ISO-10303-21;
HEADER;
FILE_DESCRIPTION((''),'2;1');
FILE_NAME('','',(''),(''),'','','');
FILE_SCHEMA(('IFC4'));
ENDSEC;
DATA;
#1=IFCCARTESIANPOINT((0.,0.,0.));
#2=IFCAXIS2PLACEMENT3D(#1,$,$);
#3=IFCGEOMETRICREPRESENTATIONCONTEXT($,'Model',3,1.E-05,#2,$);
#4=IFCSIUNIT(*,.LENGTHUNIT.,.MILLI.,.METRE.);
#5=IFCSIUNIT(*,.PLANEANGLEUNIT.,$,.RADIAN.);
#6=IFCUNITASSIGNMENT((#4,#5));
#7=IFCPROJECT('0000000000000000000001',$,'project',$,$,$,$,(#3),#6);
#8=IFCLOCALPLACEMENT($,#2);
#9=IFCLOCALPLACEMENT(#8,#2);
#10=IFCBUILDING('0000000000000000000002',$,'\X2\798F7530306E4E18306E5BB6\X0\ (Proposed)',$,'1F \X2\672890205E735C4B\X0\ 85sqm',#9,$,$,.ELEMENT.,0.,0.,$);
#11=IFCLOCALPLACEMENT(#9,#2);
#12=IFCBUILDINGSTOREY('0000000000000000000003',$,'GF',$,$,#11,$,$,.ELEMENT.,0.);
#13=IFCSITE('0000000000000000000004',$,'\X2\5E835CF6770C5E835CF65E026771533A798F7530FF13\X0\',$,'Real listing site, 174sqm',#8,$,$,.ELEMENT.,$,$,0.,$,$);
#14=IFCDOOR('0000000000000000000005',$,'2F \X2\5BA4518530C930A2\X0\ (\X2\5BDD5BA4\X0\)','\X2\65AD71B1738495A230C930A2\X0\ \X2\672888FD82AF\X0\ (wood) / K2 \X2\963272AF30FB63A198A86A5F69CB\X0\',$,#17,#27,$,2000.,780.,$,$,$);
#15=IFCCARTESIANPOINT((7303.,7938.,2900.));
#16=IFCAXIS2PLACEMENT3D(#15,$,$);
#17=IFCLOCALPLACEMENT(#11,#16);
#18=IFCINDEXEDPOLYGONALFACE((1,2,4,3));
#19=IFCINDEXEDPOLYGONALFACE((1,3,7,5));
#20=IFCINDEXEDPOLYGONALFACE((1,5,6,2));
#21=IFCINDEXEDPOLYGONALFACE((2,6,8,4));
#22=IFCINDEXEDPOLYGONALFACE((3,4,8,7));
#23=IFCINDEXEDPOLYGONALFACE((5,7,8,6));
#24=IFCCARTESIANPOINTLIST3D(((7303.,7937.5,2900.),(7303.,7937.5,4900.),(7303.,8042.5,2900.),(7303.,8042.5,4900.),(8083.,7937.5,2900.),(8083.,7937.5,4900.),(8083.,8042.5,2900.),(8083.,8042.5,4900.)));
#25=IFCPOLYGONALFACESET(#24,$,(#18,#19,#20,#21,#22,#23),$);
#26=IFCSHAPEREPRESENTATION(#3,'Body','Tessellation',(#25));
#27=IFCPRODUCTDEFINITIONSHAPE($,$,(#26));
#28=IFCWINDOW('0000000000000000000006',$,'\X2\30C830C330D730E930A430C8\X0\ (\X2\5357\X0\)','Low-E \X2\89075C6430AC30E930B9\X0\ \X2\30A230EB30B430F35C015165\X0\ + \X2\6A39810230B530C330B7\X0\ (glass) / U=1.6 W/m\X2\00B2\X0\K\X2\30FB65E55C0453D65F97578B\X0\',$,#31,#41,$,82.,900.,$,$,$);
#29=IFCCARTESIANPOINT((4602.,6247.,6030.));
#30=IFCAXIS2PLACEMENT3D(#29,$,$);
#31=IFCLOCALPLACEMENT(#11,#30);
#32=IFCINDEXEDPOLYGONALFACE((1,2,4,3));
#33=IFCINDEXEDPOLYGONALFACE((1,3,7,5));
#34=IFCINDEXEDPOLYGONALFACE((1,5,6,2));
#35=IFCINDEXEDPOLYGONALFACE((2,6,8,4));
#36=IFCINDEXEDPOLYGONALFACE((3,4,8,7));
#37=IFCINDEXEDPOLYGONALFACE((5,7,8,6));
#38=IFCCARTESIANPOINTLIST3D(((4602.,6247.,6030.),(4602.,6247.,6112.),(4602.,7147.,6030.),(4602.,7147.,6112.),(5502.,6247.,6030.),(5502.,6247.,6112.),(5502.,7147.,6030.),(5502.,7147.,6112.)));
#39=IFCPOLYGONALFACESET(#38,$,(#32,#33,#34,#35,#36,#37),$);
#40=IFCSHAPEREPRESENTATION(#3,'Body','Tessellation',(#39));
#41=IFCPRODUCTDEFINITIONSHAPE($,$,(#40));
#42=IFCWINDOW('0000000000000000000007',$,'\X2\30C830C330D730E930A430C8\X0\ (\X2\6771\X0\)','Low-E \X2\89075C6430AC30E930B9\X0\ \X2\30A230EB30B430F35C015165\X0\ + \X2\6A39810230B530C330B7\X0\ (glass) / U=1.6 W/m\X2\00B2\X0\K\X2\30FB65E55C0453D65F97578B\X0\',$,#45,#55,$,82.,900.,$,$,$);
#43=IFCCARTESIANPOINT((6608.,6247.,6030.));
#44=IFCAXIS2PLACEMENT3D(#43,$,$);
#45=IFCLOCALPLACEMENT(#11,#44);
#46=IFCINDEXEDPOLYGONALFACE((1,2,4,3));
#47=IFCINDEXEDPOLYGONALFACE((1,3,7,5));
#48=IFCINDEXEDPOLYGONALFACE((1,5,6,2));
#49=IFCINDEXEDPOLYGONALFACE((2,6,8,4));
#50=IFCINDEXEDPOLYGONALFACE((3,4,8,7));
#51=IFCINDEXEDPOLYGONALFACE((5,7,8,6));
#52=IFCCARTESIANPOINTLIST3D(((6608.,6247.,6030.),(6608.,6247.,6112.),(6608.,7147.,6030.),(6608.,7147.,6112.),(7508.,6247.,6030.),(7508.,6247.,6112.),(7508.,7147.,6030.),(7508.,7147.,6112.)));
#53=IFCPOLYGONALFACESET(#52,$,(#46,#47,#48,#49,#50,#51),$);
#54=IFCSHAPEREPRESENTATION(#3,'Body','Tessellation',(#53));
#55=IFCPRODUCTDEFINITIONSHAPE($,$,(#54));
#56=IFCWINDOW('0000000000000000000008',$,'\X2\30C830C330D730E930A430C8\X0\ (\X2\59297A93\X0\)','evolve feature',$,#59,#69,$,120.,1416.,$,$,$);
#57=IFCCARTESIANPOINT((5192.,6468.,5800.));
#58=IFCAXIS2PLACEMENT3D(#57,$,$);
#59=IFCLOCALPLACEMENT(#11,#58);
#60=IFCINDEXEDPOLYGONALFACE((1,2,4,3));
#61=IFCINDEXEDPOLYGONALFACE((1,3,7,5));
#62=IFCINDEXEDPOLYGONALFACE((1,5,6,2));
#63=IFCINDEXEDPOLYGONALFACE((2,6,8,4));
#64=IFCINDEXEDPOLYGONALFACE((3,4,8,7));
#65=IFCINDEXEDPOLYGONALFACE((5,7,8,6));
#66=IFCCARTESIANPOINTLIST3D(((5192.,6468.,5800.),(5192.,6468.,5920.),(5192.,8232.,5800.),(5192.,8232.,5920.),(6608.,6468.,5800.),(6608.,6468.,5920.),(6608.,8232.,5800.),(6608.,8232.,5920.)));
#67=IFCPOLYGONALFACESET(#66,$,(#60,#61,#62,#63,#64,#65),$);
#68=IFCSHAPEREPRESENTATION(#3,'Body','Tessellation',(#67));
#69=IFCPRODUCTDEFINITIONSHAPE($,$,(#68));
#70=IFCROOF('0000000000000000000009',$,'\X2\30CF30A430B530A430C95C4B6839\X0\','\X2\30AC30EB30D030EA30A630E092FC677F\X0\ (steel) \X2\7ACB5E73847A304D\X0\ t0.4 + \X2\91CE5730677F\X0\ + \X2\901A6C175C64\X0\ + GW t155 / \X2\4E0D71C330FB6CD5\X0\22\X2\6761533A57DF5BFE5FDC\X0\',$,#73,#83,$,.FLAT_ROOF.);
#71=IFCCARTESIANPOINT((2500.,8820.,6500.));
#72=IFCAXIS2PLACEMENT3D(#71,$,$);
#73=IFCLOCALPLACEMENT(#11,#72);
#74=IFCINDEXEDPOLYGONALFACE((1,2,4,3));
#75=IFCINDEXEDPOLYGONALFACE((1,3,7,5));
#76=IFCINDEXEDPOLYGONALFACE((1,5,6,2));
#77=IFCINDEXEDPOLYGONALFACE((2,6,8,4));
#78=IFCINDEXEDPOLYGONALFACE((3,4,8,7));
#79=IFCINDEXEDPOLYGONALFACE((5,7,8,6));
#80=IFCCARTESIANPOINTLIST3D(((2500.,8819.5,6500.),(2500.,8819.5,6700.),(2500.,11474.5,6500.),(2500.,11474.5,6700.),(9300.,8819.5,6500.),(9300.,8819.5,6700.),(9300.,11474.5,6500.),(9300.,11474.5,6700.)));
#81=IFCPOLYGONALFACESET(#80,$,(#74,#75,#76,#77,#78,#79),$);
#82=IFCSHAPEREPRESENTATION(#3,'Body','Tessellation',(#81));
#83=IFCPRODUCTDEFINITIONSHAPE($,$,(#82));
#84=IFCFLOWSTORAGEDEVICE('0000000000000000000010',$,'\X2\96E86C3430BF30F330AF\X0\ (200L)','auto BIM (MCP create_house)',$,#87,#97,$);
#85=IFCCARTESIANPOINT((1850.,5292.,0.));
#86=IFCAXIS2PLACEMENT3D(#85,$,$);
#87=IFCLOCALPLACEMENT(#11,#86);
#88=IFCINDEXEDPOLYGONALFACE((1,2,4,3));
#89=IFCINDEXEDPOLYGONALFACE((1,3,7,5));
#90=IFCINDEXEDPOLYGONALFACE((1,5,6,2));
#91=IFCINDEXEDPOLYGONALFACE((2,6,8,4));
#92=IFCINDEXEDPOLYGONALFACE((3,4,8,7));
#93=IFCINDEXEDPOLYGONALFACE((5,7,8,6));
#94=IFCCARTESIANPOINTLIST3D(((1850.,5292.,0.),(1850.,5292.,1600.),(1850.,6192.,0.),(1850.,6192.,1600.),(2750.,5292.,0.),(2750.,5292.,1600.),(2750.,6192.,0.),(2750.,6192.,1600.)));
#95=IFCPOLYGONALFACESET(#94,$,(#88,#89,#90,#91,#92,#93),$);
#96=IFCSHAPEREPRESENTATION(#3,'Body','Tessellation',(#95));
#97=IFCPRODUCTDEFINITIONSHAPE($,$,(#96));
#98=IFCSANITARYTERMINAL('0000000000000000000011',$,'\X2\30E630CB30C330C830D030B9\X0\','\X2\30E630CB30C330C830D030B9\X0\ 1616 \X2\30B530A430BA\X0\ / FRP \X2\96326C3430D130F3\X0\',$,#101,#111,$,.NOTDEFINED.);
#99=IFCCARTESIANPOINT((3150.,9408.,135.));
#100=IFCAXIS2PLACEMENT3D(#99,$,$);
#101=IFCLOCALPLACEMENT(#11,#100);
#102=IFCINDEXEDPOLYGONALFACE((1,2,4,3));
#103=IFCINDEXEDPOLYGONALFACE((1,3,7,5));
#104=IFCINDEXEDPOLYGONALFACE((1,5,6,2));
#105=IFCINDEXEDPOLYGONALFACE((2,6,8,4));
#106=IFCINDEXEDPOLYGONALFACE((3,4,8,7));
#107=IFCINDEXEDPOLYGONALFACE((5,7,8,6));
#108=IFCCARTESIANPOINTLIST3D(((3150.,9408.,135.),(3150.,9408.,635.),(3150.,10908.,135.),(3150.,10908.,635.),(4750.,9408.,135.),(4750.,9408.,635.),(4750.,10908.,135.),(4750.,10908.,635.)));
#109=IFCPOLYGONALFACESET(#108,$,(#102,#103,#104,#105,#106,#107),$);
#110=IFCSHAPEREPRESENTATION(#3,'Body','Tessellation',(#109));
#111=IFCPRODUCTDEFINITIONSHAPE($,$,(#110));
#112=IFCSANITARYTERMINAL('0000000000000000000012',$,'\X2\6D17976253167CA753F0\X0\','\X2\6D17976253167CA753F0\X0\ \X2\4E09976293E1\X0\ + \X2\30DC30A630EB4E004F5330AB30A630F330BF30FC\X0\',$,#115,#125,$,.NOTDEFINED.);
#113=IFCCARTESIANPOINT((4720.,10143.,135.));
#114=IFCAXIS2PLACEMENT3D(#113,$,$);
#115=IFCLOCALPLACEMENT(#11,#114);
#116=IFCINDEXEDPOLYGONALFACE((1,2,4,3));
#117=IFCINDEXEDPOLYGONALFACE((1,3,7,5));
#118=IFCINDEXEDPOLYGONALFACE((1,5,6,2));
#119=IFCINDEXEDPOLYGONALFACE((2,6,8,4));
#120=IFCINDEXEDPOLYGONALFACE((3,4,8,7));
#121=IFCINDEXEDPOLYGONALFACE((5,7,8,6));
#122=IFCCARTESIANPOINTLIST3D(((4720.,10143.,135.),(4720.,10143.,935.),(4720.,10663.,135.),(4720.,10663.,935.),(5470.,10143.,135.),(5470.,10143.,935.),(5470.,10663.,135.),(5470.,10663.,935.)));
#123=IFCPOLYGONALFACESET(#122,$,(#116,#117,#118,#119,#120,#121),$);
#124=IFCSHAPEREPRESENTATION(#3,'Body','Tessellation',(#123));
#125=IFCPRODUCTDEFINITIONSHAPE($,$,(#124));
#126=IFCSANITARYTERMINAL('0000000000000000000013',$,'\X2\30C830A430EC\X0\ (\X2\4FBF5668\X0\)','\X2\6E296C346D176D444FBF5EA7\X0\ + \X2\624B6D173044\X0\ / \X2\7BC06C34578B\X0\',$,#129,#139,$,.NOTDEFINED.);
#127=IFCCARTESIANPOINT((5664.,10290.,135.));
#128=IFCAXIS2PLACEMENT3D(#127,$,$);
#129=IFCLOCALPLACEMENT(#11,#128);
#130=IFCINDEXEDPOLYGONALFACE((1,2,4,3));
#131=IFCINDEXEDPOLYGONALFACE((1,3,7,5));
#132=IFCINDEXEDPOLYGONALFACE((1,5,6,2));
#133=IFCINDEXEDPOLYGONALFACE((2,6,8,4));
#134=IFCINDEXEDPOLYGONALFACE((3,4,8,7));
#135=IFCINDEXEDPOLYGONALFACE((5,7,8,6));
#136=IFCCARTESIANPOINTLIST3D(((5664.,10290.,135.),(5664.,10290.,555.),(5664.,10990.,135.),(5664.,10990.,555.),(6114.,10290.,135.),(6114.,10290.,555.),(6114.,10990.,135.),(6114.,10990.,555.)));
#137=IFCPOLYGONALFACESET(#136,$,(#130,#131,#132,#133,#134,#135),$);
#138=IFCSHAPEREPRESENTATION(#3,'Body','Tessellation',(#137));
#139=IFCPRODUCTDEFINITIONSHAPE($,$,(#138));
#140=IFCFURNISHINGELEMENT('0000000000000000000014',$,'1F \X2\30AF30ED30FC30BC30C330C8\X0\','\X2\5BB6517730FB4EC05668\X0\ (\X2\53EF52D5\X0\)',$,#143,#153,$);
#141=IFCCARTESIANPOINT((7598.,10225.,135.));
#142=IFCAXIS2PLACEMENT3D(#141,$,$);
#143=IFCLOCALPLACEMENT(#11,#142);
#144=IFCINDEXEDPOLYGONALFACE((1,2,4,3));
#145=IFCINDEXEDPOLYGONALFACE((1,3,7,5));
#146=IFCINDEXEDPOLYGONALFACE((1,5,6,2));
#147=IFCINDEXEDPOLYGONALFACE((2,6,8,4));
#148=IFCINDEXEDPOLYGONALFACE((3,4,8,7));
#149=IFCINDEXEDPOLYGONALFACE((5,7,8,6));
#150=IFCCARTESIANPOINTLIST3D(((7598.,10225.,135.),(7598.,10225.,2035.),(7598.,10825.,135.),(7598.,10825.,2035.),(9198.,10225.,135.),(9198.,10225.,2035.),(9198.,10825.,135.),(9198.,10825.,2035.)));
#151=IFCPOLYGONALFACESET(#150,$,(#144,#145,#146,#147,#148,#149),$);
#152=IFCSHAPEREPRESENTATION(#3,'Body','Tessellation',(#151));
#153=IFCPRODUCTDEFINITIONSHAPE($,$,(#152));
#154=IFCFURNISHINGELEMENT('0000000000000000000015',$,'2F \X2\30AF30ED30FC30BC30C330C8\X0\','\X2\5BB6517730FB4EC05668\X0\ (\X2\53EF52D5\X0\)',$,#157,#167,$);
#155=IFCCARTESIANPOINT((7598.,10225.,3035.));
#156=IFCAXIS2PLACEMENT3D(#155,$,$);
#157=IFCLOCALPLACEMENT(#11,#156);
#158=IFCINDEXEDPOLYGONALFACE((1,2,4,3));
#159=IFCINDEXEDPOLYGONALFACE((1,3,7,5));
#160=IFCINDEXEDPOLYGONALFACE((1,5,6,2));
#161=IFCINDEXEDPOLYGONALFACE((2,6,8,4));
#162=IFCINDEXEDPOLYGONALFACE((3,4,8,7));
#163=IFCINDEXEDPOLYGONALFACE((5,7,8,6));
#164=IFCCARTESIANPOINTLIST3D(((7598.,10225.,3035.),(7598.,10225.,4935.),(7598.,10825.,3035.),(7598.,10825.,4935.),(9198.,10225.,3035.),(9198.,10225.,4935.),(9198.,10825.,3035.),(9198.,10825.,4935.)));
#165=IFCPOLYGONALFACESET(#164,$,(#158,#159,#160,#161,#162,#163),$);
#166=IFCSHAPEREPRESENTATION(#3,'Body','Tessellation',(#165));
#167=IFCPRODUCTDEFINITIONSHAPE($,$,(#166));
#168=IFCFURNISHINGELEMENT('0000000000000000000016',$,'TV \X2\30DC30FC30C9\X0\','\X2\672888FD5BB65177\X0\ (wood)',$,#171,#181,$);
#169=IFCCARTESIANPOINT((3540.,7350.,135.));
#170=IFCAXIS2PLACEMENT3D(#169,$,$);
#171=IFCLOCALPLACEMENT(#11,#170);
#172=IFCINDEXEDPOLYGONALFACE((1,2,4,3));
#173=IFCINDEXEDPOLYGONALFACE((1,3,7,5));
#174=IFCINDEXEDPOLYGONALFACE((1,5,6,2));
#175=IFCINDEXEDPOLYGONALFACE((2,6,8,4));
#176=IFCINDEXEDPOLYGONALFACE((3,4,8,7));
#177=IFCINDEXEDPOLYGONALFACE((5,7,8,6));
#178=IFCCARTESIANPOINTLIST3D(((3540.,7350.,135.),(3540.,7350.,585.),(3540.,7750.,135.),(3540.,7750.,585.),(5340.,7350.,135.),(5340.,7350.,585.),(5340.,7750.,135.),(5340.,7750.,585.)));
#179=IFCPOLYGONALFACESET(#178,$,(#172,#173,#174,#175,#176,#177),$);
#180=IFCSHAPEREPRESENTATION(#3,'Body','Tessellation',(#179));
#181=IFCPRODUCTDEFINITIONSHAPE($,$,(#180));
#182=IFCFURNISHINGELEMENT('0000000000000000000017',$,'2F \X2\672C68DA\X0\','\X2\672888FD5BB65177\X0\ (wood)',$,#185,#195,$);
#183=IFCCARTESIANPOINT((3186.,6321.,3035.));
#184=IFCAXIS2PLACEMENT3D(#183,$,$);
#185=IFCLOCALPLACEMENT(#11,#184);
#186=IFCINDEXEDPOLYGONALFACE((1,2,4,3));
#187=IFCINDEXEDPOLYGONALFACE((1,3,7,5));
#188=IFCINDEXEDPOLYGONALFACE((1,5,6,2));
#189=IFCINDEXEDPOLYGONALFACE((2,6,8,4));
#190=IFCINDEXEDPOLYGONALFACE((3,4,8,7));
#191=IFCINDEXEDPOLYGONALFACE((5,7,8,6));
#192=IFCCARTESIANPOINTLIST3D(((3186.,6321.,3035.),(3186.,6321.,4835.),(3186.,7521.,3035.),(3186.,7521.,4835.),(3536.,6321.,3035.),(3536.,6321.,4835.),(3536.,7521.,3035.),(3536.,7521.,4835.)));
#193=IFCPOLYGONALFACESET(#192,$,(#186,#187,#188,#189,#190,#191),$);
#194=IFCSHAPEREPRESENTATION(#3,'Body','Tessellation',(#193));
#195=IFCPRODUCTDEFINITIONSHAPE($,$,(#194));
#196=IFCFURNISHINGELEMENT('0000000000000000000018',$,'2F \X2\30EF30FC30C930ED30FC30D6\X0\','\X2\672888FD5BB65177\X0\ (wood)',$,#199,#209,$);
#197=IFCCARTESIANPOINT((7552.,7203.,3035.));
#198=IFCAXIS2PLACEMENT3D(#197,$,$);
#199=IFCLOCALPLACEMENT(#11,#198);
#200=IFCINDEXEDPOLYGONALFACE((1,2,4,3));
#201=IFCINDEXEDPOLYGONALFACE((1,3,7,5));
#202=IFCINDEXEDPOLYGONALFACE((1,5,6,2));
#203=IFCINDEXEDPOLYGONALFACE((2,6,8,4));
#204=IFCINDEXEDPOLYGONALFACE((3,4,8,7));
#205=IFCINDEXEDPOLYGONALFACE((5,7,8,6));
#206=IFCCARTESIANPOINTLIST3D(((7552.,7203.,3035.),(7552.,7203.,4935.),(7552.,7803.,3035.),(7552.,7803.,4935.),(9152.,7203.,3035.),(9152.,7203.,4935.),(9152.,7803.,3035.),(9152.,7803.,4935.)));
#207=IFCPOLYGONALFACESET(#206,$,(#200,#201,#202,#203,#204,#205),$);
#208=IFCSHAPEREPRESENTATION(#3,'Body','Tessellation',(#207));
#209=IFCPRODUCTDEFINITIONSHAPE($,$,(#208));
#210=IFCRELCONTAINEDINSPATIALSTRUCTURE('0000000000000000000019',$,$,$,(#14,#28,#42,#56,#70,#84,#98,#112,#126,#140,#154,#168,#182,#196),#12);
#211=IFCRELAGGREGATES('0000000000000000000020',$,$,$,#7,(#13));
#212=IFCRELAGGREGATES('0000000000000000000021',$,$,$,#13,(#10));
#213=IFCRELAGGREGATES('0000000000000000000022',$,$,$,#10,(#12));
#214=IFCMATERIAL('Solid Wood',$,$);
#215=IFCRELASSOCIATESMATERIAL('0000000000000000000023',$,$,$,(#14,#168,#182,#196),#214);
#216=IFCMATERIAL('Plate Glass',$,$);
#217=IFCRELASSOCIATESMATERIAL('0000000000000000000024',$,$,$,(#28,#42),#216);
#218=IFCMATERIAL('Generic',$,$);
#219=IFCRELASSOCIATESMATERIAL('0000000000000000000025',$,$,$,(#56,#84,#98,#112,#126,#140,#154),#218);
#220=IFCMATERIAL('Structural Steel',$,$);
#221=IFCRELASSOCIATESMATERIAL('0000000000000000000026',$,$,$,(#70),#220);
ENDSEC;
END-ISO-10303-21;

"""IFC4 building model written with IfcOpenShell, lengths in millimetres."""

from ifc_helpers import new_model, si_unit, frame, frame_2d, origin, place, context, project, spatial, rectangle, extrude, material, element, save


model = new_model("IFC4")

# Units and contexts
model_context = context("Model", 3, precision=1e-05, world=origin())
ifc_project = project(units=[si_unit("LENGTHUNIT", "METRE", prefix="MILLI"), si_unit("PLANEANGLEUNIT", "RADIAN")], contexts=[model_context])

# Site, building, storey
site_placement = place(None, origin())
site = spatial("IfcSite", under=ifc_project, at=site_placement, Name="広島県広島市東区福田３", ObjectType="Real listing site, 174sqm", CompositionType="ELEMENT", RefElevation=0.0)
building_placement = place(site_placement, origin())
building = spatial("IfcBuilding", under=site, at=building_placement, Name="福田の丘の家 (Proposed)", ObjectType="1F 木造平屋 85sqm", CompositionType="ELEMENT", ElevationOfRefHeight=0.0, ElevationOfTerrain=0.0)
storey_placement = place(building_placement, origin())
storey = spatial("IfcBuildingStorey", under=building, at=storey_placement, Name="GF", CompositionType="ELEMENT", Elevation=0.0)

# Shared definitions
ifc_material_1 = material(Name="Solid Wood")
ifc_material_2 = material(Name="Plate Glass")

# Door
door_1_placement = place(storey_placement, frame((7303.0, 7938.0, 2900.0)))
element("IfcDoor", 1, at=door_1_placement, inside=storey, material=ifc_material_1, Name="2F 室内ドア (寝室)", Description="断熱玄関ドア 木製芯 (wood) / K2 防犯・採風機構", OverallHeight=2000.0, OverallWidth=780.0, context=model_context, shape_type="SweptSolid", body=[
    extrude(rectangle(XDim=780.0, YDim=105.0, at=frame_2d((390.0, 52.0))), frame((7303.0, 7938.0, 2900.0)), (0.0, 0.0, 1.0), 2000.0),
])

# Windows
window_1_placement = place(storey_placement, frame((4602.0, 6247.0, 6030.0)))
element("IfcWindow", 2, at=window_1_placement, inside=storey, material=ifc_material_2, Name="トップライト (南)", Description="Low-E 複層ガラス アルゴン封入 + 樹脂サッシ (glass) / U=1.6 W/m²K・日射取得型", OverallHeight=82.0, OverallWidth=900.0, context=model_context, shape_type="SweptSolid", body=[
    extrude(rectangle(XDim=900.0, YDim=900.0, at=frame_2d((450.0, 450.0))), frame((4602.0, 6247.0, 6030.0)), (0.0, 0.0, 1.0), 82.0),
])
window_2_placement = place(storey_placement, frame((6608.0, 6247.0, 6030.0)))
element("IfcWindow", 3, at=window_2_placement, inside=storey, material=ifc_material_2, Name="トップライト (東)", Description="Low-E 複層ガラス アルゴン封入 + 樹脂サッシ (glass) / U=1.6 W/m²K・日射取得型", OverallHeight=82.0, OverallWidth=900.0, context=model_context, shape_type="SweptSolid", body=[
    extrude(rectangle(XDim=900.0, YDim=900.0, at=frame_2d((450.0, 450.0))), frame((6608.0, 6247.0, 6030.0)), (0.0, 0.0, 1.0), 82.0),
])
ifc_material_3 = material(Name="Generic")
window_3_placement = place(storey_placement, frame((5192.0, 6468.0, 5800.0)))
element("IfcWindow", 4, at=window_3_placement, inside=storey, material=ifc_material_3, Name="トップライト (天窓)", Description="evolve feature", OverallHeight=120.0, OverallWidth=1416.0, context=model_context, shape_type="SweptSolid", body=[
    extrude(rectangle(XDim=1416.0, YDim=1764.0, at=frame_2d((708.0, 882.0))), frame((5192.0, 6468.0, 5800.0)), (0.0, 0.0, 1.0), 120.0),
])

# Roof
ifc_material_4 = material(Name="Structural Steel")
roof_placement = place(storey_placement, frame((2500.0, 8820.0, 6500.0)))
element("IfcRoof", 5, at=roof_placement, inside=storey, material=ifc_material_4, Name="ハイサイド屋根", Description="ガルバリウム鋼板 (steel) 立平葺き t0.4 + 野地板 + 通気層 + GW t155 / 不燃・法22条区域対応", PredefinedType="FLAT_ROOF", context=model_context, shape_type="SweptSolid", body=[
    extrude(rectangle(XDim=6800.0, YDim=2655.0, at=frame_2d((3400.0, 1327.0))), frame((2500.0, 8820.0, 6500.0)), (0.0, 0.0, 1.0), 200.0),
])

# Flow storage device
flow_storage_device_placement = place(storey_placement, frame((1850.0, 5292.0, 0.0)))
element("IfcFlowStorageDevice", 6, at=flow_storage_device_placement, inside=storey, material=ifc_material_3, Name="雨水タンク (200L)", Description="auto BIM (MCP create_house)", context=model_context, shape_type="SweptSolid", body=[
    extrude(rectangle(XDim=900.0, YDim=900.0, at=frame_2d((450.0, 450.0))), frame((1850.0, 5292.0, 0.0)), (0.0, 0.0, 1.0), 1600.0),
])

# Sanitary terminals
sanitary_terminal_1_placement = place(storey_placement, frame((3150.0, 9408.0, 135.0)))
element("IfcSanitaryTerminal", 7, at=sanitary_terminal_1_placement, inside=storey, material=ifc_material_3, Name="ユニットバス", Description="ユニットバス 1616 サイズ / FRP 防水パン", PredefinedType="NOTDEFINED", context=model_context, shape_type="SweptSolid", body=[
    extrude(rectangle(XDim=1600.0, YDim=1500.0, at=frame_2d((800.0, 750.0))), frame((3150.0, 9408.0, 135.0)), (0.0, 0.0, 1.0), 500.0),
])
sanitary_terminal_2_placement = place(storey_placement, frame((4720.0, 10143.0, 135.0)))
element("IfcSanitaryTerminal", 8, at=sanitary_terminal_2_placement, inside=storey, material=ifc_material_3, Name="洗面化粧台", Description="洗面化粧台 三面鏡 + ボウル一体カウンター", PredefinedType="NOTDEFINED", context=model_context, shape_type="SweptSolid", body=[
    extrude(rectangle(XDim=750.0, YDim=520.0, at=frame_2d((375.0, 260.0))), frame((4720.0, 10143.0, 135.0)), (0.0, 0.0, 1.0), 800.0),
])
sanitary_terminal_3_placement = place(storey_placement, frame((5664.0, 10290.0, 135.0)))
element("IfcSanitaryTerminal", 9, at=sanitary_terminal_3_placement, inside=storey, material=ifc_material_3, Name="トイレ (便器)", Description="温水洗浄便座 + 手洗い / 節水型", PredefinedType="NOTDEFINED", context=model_context, shape_type="SweptSolid", body=[
    extrude(rectangle(XDim=450.0, YDim=700.0, at=frame_2d((225.0, 350.0))), frame((5664.0, 10290.0, 135.0)), (0.0, 0.0, 1.0), 420.0),
])

# Furnishing elements
furnishing_1_placement = place(storey_placement, frame((7598.0, 10225.0, 135.0)))
element("IfcFurnishingElement", 10, at=furnishing_1_placement, inside=storey, material=ifc_material_3, Name="1F クローゼット", Description="家具・什器 (可動)", context=model_context, shape_type="SweptSolid", body=[
    extrude(rectangle(XDim=1600.0, YDim=600.0, at=frame_2d((800.0, 300.0))), frame((7598.0, 10225.0, 135.0)), (0.0, 0.0, 1.0), 1900.0),
])
furnishing_2_placement = place(storey_placement, frame((7598.0, 10225.0, 3035.0)))
element("IfcFurnishingElement", 11, at=furnishing_2_placement, inside=storey, material=ifc_material_3, Name="2F クローゼット", Description="家具・什器 (可動)", context=model_context, shape_type="SweptSolid", body=[
    extrude(rectangle(XDim=1600.0, YDim=600.0, at=frame_2d((800.0, 300.0))), frame((7598.0, 10225.0, 3035.0)), (0.0, 0.0, 1.0), 1900.0),
])
furnishing_3_placement = place(storey_placement, frame((3540.0, 7350.0, 135.0)))
element("IfcFurnishingElement", 12, at=furnishing_3_placement, inside=storey, material=ifc_material_1, Name="TV ボード", Description="木製家具 (wood)", context=model_context, shape_type="SweptSolid", body=[
    extrude(rectangle(XDim=1800.0, YDim=400.0, at=frame_2d((900.0, 200.0))), frame((3540.0, 7350.0, 135.0)), (0.0, 0.0, 1.0), 450.0),
])
furnishing_4_placement = place(storey_placement, frame((3186.0, 6321.0, 3035.0)))
element("IfcFurnishingElement", 13, at=furnishing_4_placement, inside=storey, material=ifc_material_1, Name="2F 本棚", Description="木製家具 (wood)", context=model_context, shape_type="SweptSolid", body=[
    extrude(rectangle(XDim=350.0, YDim=1200.0, at=frame_2d((175.0, 600.0))), frame((3186.0, 6321.0, 3035.0)), (0.0, 0.0, 1.0), 1800.0),
])
furnishing_5_placement = place(storey_placement, frame((7552.0, 7203.0, 3035.0)))
element("IfcFurnishingElement", 14, at=furnishing_5_placement, inside=storey, material=ifc_material_1, Name="2F ワードローブ", Description="木製家具 (wood)", context=model_context, shape_type="SweptSolid", body=[
    extrude(rectangle(XDim=1600.0, YDim=600.0, at=frame_2d((800.0, 300.0))), frame((7552.0, 7203.0, 3035.0)), (0.0, 0.0, 1.0), 1900.0),
])

save(model, "model.ifc")
